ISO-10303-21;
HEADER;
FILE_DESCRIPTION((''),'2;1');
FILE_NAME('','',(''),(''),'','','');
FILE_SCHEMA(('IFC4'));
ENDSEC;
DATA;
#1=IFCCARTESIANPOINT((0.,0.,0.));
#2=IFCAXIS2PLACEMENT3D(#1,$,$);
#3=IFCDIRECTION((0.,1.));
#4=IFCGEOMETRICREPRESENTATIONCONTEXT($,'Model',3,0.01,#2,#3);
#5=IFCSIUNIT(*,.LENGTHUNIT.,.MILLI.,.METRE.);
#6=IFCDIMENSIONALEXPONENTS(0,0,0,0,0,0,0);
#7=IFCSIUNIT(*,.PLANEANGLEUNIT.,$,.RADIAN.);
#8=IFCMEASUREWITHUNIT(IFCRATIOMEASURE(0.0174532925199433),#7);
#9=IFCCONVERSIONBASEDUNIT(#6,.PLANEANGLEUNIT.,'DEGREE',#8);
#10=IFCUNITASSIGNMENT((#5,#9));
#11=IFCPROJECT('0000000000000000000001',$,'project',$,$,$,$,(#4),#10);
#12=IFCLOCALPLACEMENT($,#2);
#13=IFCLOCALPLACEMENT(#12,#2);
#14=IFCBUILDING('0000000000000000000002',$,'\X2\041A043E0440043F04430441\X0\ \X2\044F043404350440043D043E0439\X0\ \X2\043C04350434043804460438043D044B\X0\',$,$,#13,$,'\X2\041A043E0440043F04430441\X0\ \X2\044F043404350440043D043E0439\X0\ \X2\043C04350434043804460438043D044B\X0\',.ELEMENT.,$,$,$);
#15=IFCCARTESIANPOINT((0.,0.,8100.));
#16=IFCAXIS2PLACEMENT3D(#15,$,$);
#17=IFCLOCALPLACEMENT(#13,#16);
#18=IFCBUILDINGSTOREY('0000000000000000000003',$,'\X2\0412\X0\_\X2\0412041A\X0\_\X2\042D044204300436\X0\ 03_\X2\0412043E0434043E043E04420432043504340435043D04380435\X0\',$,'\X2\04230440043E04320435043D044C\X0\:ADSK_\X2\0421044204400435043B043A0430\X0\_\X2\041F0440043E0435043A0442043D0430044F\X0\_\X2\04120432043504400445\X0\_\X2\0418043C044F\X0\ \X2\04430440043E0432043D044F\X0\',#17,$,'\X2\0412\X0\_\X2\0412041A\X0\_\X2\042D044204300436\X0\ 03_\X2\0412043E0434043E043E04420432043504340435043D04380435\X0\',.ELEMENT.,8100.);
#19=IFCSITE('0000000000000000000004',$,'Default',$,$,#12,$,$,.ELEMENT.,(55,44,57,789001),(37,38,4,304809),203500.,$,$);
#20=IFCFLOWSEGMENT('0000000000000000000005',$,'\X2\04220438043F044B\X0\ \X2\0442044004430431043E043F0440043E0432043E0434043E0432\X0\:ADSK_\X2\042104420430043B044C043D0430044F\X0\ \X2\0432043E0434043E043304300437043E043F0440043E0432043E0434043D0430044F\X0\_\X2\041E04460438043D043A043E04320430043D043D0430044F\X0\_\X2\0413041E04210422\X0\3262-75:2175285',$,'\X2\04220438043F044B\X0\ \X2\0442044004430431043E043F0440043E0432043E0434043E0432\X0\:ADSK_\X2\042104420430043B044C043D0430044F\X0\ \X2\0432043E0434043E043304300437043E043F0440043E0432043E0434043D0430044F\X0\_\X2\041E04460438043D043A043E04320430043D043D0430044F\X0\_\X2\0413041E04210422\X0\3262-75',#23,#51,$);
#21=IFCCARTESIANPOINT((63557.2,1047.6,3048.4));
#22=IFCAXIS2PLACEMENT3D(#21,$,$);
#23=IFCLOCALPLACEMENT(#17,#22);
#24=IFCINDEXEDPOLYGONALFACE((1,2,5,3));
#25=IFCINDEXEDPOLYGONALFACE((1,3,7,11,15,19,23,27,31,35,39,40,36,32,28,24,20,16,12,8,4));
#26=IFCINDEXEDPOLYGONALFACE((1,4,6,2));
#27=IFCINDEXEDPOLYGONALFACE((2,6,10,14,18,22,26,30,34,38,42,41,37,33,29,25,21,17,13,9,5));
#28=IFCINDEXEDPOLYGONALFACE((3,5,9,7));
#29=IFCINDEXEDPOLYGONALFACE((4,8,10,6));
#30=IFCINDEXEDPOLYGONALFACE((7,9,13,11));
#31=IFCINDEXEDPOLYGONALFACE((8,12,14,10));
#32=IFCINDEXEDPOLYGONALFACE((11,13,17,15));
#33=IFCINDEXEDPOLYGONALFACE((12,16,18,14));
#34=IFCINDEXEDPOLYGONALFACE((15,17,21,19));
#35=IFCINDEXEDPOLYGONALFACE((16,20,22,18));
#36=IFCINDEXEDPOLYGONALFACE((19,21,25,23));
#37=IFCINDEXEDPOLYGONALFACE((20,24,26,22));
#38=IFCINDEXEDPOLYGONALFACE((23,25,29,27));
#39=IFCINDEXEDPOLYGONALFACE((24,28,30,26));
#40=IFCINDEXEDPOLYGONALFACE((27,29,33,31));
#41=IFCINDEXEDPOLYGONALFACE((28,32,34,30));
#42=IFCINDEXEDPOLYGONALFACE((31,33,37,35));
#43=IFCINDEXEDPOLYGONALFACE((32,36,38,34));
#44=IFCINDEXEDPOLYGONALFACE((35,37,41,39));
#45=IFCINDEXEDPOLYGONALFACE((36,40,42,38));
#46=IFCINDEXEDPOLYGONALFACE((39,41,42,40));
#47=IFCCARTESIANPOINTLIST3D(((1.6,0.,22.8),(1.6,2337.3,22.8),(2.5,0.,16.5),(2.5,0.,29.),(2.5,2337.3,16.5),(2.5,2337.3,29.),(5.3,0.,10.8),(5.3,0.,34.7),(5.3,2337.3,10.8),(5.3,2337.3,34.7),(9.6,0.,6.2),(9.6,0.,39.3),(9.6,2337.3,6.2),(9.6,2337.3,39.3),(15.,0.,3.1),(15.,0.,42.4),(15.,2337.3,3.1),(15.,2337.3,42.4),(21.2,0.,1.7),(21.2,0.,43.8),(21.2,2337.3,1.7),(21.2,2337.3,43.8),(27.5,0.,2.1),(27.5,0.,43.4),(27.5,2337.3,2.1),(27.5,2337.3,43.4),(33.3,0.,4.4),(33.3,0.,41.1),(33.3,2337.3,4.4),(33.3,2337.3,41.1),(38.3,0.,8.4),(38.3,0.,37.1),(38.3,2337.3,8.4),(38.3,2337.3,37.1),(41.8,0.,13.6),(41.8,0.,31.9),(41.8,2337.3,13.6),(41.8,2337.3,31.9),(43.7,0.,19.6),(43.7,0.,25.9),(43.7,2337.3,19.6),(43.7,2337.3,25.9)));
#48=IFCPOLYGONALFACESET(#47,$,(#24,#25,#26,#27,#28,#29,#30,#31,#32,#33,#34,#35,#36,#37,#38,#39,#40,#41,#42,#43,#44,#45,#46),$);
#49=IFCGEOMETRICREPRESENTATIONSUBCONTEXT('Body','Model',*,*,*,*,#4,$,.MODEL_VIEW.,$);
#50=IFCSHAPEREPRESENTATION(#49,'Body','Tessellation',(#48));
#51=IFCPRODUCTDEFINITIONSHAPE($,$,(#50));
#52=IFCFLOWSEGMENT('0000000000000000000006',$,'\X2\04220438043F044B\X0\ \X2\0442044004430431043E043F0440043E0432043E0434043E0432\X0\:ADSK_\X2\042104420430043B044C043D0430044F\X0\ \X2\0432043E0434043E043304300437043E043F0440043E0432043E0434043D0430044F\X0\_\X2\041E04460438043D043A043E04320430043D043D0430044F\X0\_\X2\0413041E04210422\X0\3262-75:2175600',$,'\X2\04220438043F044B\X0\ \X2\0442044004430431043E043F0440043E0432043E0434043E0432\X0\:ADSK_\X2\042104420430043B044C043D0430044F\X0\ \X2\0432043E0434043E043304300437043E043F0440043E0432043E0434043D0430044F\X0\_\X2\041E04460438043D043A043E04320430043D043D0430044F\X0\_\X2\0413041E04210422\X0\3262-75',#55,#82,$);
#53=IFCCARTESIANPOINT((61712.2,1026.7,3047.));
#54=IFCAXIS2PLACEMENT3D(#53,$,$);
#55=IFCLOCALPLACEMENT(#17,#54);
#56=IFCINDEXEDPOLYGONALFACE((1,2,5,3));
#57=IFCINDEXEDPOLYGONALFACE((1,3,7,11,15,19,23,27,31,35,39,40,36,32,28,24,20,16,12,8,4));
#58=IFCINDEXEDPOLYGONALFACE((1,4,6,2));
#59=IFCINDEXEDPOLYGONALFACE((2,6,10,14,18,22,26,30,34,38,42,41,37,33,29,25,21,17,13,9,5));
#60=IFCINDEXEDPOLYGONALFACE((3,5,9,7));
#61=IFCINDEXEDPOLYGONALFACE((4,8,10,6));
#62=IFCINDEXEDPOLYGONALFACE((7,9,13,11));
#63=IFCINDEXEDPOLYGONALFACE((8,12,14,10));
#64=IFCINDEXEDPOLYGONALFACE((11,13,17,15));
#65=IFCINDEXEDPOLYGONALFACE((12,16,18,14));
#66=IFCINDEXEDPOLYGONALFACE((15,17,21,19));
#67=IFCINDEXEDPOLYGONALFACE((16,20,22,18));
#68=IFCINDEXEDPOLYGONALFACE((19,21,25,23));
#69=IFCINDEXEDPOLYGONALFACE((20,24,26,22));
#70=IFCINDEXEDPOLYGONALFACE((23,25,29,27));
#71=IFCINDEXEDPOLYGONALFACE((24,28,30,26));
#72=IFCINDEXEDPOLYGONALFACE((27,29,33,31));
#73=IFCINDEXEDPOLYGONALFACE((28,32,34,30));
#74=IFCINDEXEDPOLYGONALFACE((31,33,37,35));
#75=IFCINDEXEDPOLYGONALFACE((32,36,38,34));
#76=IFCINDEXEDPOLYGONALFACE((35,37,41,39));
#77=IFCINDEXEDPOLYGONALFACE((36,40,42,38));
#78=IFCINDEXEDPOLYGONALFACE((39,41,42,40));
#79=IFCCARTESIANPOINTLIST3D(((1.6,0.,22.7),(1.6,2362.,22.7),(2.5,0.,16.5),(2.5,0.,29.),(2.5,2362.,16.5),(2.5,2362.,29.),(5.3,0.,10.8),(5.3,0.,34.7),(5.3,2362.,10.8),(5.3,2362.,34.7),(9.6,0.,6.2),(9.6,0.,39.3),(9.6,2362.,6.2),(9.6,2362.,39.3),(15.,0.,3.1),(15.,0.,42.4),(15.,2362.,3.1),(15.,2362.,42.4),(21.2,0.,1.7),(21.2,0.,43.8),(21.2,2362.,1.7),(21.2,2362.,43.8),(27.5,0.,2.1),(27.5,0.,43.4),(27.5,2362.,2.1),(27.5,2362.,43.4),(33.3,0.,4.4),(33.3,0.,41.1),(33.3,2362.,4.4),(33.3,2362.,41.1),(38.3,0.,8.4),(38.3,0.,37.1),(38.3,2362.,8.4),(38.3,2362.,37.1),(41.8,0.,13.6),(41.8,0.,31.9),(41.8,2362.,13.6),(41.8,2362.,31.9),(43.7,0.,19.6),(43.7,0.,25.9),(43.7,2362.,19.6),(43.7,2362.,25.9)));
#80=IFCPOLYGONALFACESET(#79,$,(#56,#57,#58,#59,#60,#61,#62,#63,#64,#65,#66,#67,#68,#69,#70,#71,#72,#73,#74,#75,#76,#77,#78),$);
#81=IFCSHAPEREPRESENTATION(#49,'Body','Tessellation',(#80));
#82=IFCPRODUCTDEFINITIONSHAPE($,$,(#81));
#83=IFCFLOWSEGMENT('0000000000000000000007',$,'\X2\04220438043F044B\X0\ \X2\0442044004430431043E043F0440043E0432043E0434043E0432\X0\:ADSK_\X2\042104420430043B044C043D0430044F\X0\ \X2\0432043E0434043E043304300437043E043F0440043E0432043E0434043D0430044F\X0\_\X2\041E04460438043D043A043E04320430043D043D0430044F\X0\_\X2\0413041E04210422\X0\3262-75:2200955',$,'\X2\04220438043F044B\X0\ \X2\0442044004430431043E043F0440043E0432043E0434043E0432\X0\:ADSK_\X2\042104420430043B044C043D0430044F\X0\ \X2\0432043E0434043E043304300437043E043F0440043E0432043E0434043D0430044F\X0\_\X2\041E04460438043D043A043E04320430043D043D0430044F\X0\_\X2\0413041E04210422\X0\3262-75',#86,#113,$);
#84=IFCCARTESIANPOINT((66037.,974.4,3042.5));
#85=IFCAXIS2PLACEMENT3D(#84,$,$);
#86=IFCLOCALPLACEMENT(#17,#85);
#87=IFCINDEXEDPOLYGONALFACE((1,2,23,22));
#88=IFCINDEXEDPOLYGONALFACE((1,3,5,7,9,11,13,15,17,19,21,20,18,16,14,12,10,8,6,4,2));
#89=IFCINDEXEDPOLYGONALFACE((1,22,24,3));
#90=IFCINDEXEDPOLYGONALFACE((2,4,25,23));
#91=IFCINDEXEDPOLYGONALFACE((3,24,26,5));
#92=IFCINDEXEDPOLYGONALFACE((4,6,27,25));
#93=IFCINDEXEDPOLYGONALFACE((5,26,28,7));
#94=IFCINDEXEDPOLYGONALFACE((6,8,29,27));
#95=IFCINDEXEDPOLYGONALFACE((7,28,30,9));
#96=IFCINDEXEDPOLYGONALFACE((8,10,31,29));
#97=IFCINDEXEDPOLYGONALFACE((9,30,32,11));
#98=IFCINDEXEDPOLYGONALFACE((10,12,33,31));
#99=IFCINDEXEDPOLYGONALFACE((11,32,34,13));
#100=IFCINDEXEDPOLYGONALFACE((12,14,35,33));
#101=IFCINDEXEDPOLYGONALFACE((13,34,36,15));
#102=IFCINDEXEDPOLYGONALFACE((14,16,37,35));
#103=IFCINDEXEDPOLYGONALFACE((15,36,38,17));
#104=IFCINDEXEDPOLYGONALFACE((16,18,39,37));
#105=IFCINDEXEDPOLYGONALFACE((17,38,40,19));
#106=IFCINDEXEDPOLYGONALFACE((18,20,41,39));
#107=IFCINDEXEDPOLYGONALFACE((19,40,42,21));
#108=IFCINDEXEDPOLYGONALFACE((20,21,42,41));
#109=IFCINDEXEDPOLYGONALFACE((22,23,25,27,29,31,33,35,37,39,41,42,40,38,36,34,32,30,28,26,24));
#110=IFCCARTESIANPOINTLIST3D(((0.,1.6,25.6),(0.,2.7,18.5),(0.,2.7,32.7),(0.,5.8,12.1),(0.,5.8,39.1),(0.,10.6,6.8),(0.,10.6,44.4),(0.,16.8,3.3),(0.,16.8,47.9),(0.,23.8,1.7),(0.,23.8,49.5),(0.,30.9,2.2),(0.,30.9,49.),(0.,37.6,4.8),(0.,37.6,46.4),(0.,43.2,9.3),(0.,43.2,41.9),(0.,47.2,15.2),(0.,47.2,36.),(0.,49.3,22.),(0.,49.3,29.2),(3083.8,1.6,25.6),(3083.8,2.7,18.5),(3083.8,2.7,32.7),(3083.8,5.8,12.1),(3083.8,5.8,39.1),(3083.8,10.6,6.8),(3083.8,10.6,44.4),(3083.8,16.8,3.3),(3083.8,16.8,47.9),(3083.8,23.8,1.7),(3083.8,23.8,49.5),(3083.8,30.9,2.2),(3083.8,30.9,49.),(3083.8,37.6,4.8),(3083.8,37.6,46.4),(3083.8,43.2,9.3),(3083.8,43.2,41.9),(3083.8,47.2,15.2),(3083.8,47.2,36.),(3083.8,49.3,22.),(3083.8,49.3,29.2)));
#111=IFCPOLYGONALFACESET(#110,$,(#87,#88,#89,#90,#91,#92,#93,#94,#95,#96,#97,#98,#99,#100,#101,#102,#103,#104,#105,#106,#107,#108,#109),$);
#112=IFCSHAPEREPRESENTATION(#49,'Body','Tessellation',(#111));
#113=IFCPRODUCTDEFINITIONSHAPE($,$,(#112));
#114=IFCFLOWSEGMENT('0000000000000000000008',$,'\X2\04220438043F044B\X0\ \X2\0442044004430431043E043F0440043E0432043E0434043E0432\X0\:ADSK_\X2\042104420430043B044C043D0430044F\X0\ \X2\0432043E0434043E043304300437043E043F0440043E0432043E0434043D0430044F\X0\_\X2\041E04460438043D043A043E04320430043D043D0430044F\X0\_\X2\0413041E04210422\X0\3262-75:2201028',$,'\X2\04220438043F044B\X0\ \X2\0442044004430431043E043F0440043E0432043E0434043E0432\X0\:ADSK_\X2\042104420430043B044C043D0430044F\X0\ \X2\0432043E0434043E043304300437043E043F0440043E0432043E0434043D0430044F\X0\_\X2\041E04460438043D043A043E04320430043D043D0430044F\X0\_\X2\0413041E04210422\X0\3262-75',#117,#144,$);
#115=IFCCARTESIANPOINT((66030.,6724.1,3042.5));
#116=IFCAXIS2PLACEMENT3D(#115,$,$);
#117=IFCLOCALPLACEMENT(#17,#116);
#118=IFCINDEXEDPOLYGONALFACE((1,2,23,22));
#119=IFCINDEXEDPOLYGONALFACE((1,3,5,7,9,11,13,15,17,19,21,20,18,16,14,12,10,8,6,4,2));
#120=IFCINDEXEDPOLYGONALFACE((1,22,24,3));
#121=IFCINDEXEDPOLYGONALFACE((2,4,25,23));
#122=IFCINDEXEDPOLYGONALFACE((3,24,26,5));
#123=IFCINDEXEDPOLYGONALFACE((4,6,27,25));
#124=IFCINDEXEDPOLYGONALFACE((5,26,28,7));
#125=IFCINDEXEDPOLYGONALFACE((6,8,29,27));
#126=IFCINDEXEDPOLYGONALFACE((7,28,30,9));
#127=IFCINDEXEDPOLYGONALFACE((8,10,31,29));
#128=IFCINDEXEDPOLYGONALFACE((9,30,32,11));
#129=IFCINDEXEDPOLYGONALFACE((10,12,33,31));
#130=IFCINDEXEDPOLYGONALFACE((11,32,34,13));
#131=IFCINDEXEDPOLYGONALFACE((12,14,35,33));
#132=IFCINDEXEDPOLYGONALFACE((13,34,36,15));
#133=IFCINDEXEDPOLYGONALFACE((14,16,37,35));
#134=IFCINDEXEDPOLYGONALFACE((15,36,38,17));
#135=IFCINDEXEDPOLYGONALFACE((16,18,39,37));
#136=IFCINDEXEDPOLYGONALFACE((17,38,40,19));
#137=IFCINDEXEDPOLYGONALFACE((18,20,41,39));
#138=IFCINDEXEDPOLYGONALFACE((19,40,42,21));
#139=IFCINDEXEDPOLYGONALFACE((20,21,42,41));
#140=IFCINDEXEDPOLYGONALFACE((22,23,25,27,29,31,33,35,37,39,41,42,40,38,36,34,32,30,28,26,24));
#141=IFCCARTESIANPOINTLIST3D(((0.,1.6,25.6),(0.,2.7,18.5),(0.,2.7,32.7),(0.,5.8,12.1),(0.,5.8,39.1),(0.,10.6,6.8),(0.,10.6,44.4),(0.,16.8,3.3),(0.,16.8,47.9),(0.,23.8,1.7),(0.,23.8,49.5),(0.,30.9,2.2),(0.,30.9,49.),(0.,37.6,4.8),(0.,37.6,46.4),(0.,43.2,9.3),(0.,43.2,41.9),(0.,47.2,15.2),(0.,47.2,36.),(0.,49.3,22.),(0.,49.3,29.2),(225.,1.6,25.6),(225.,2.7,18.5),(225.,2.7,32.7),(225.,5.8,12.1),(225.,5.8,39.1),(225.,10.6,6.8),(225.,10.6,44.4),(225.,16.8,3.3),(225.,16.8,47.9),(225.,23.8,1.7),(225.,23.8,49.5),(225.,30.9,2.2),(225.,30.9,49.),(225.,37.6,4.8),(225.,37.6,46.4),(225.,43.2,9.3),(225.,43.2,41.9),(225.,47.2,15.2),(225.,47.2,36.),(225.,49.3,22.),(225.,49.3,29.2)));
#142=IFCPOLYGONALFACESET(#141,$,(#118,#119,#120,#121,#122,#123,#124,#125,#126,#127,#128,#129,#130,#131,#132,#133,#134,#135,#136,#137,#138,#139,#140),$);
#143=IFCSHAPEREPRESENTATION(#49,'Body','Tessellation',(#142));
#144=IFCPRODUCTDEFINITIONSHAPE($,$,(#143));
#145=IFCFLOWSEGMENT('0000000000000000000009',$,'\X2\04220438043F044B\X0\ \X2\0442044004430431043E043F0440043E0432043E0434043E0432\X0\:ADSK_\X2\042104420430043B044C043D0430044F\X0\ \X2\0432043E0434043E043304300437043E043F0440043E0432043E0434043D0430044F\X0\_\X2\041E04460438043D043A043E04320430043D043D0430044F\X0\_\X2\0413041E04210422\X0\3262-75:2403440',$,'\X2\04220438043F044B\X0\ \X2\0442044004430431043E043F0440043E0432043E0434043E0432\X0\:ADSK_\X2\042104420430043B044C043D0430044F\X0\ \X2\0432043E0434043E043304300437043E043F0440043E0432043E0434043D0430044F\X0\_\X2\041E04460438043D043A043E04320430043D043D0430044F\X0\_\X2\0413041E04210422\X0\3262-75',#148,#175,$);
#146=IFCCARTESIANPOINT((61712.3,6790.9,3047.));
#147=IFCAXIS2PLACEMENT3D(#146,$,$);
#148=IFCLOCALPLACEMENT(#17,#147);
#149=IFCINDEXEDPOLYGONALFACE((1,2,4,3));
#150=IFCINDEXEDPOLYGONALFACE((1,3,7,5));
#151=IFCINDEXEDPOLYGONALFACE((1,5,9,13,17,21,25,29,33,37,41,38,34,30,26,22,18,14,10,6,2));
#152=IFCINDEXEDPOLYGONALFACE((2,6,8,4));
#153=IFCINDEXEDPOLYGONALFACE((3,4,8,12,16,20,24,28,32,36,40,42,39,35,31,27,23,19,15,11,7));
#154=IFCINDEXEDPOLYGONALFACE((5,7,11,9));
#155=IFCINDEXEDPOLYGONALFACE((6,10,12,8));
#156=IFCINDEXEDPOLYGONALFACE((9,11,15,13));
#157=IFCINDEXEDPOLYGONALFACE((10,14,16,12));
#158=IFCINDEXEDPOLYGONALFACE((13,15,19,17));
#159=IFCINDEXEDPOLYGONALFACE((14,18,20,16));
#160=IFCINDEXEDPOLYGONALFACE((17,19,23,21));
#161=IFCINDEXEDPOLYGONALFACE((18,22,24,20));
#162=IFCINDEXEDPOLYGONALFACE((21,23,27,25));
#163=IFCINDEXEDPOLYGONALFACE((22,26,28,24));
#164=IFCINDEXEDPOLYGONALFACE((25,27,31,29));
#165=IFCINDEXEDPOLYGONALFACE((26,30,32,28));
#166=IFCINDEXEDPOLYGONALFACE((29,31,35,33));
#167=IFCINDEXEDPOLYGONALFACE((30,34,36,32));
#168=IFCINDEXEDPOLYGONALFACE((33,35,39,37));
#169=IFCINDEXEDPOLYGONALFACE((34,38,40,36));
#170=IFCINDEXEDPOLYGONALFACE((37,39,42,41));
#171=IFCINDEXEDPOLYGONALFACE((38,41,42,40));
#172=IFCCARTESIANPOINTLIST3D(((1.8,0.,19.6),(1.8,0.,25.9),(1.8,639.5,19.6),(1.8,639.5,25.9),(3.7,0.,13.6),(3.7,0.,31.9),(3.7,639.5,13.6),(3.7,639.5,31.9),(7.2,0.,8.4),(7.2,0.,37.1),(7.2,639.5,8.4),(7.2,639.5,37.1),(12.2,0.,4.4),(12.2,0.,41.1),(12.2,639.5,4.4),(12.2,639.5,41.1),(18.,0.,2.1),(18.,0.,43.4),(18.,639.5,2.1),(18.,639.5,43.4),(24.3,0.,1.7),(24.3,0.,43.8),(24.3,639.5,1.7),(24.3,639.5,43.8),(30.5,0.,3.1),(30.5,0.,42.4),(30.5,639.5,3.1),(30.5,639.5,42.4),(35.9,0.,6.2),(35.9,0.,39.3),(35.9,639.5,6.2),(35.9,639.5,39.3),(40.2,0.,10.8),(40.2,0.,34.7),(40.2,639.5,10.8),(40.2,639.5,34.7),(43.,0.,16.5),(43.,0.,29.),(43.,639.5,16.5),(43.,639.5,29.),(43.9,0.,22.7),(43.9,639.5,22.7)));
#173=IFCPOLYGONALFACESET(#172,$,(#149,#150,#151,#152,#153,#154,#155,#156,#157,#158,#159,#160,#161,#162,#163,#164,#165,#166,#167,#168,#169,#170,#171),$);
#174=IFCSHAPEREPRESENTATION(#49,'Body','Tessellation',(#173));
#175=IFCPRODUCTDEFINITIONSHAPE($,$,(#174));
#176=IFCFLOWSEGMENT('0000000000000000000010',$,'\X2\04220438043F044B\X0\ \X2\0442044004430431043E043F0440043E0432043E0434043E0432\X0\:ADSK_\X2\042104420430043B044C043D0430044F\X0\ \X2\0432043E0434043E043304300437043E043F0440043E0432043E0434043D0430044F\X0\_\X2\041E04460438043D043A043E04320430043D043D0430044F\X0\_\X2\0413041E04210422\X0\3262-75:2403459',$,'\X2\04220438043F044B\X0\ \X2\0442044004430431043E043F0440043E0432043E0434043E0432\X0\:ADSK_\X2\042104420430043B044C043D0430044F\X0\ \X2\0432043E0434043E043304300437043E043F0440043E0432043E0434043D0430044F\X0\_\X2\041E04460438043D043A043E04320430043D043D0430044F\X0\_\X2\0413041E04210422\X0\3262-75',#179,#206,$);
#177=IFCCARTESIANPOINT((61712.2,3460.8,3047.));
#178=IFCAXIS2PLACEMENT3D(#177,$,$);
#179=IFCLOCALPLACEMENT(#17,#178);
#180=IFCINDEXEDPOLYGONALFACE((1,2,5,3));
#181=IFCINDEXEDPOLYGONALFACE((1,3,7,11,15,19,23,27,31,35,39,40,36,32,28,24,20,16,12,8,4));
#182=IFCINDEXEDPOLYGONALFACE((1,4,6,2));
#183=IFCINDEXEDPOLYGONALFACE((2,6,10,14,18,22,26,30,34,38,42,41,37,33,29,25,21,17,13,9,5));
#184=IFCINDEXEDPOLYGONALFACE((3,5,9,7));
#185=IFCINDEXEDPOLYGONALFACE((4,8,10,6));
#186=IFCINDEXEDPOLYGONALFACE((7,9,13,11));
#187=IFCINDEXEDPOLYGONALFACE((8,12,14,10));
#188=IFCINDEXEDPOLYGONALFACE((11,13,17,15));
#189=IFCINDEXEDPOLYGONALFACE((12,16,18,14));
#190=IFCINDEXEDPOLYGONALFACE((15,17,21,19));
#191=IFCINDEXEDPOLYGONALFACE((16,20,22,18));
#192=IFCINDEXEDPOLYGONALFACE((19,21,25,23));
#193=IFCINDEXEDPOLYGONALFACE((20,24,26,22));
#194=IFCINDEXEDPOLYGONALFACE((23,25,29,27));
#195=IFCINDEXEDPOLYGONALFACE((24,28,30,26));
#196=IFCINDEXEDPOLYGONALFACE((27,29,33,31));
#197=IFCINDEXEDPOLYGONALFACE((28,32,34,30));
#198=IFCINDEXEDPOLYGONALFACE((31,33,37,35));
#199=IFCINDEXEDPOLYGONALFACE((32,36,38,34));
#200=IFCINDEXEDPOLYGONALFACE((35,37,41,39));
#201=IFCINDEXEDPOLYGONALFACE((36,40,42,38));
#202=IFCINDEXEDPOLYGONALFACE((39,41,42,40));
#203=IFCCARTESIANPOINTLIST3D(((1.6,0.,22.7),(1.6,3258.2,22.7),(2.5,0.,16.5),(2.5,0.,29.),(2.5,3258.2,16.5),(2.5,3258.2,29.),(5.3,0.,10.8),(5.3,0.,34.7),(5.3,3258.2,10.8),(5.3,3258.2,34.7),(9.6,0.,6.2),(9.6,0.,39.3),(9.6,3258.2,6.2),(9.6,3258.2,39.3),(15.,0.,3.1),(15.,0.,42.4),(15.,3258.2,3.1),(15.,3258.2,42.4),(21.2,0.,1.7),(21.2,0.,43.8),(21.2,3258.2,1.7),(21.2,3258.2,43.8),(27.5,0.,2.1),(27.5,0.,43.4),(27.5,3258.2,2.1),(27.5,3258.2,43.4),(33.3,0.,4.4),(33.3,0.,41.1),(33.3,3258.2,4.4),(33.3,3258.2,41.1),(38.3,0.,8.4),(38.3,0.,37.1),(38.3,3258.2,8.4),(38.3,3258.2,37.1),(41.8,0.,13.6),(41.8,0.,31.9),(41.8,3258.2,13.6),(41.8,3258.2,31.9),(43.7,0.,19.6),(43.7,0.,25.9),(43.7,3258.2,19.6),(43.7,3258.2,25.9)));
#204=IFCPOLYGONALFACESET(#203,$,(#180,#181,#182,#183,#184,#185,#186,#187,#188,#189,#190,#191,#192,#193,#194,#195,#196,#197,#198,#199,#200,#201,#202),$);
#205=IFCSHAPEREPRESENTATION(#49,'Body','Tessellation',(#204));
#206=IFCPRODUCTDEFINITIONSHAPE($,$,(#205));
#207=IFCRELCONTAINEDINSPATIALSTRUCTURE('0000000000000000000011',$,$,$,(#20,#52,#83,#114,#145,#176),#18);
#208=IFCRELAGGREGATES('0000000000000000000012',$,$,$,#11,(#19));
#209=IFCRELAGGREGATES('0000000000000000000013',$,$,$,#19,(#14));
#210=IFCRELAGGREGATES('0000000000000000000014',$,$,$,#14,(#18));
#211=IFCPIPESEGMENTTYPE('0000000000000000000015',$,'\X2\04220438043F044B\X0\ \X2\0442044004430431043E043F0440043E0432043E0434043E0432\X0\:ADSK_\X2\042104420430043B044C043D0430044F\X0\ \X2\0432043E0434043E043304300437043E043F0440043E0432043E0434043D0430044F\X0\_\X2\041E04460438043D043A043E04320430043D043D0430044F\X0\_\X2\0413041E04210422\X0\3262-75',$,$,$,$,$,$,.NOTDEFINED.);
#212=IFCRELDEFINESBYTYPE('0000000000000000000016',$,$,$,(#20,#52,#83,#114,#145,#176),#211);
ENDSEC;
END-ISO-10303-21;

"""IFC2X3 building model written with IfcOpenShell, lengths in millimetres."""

from ifc_helpers import new_model, entity, si_unit, converted_unit, direction, frame, origin, origin_2d_with_axis, place, context, subcontext, project, spatial, circle, extrude, type_object, element, save


model = new_model("IFC2X3")

# Units and contexts
model_context = context("Model", 3, precision=0.01, world=origin(), true_north=direction((0.0, 1.0)))
body_context = subcontext(model_context, "Body", "Model", "MODEL_VIEW")
ifc_project = project(units=[si_unit("LENGTHUNIT", "METRE", prefix="MILLI"), converted_unit("PLANEANGLEUNIT", "DEGREE", entity("IfcRatioMeasure", 0.0174532925199433), si_unit("PLANEANGLEUNIT", "RADIAN"), dimensions=[0, 0, 0, 0, 0, 0, 0])], contexts=[model_context])

# Site, building, storey
site_placement = place(None, origin())
site = spatial("IfcSite", under=ifc_project, at=site_placement, Name="Default", CompositionType="ELEMENT", RefLatitude=(55, 44, 57, 789001), RefLongitude=(37, 38, 4, 304809), RefElevation=203500.0)
building_placement = place(site_placement, origin())
building = spatial("IfcBuilding", under=site, at=building_placement, Name="Корпус ядерной медицины", LongName="Корпус ядерной медицины", CompositionType="ELEMENT")
storey_placement = place(building_placement, frame((0.0, 0.0, 8100.0)))
storey = spatial("IfcBuildingStorey", under=building, at=storey_placement, Name="В_ВК_Этаж 03_Водоотведение", ObjectType="Уровень:ADSK_Стрелка_Проектная_Вверх_Имя уровня", LongName="В_ВК_Этаж 03_Водоотведение", CompositionType="ELEMENT", Elevation=8100.0)

# Flow segments
pipe_segment_type_1 = type_object("IfcPipeSegmentType", Name="Типы трубопроводов:ADSK_Стальная водогазопроводная_Оцинкованная_ГОСТ3262-75", PredefinedType="NOTDEFINED")
flow_segment_1_placement = place(storey_placement, frame((63557.2, 1047.6, 3048.4)))
element("IfcFlowSegment", 1, at=flow_segment_1_placement, inside=storey, type_object=pipe_segment_type_1, Name="Типы трубопроводов:ADSK_Стальная водогазопроводная_Оцинкованная_ГОСТ3262-75:2175285", ObjectType="Типы трубопроводов:ADSK_Стальная водогазопроводная_Оцинкованная_ГОСТ3262-75", context=body_context, shape_type="SweptSolid", body=[
    extrude(circle(Radius=21.1, at=origin_2d_with_axis()), frame((22.8, 0.0, 22.8), z_axis=(0.0, 1.0, 0.0), x_axis=(-1.0, 0.0, 0.0)), (0.0, 0.0, 1.0), 2337.3),
])
flow_segment_2_placement = place(storey_placement, frame((61712.2, 1026.7, 3047.0)))
element("IfcFlowSegment", 2, at=flow_segment_2_placement, inside=storey, type_object=pipe_segment_type_1, Name="Типы трубопроводов:ADSK_Стальная водогазопроводная_Оцинкованная_ГОСТ3262-75:2175600", ObjectType="Типы трубопроводов:ADSK_Стальная водогазопроводная_Оцинкованная_ГОСТ3262-75", context=body_context, shape_type="SweptSolid", body=[
    extrude(circle(Radius=21.1, at=origin_2d_with_axis()), frame((22.8, 0.0, 22.8), z_axis=(0.0, 1.0, 0.0), x_axis=(-1.0, 0.0, 0.0)), (0.0, 0.0, 1.0), 2362.0),
])
flow_segment_3_placement = place(storey_placement, frame((66037.0, 974.4, 3042.5)))
element("IfcFlowSegment", 3, at=flow_segment_3_placement, inside=storey, type_object=pipe_segment_type_1, Name="Типы трубопроводов:ADSK_Стальная водогазопроводная_Оцинкованная_ГОСТ3262-75:2200955", ObjectType="Типы трубопроводов:ADSK_Стальная водогазопроводная_Оцинкованная_ГОСТ3262-75", context=body_context, shape_type="SweptSolid", body=[
    extrude(circle(Radius=24.0, at=origin_2d_with_axis()), frame((0.0, 25.6, 25.6), z_axis=(1.0, 0.0, 0.0), x_axis=(0.0, -1.0, 0.0)), (0.0, 0.0, 1.0), 3083.8),
])
flow_segment_4_placement = place(storey_placement, frame((66030.0, 6724.1, 3042.5)))
element("IfcFlowSegment", 4, at=flow_segment_4_placement, inside=storey, type_object=pipe_segment_type_1, Name="Типы трубопроводов:ADSK_Стальная водогазопроводная_Оцинкованная_ГОСТ3262-75:2201028", ObjectType="Типы трубопроводов:ADSK_Стальная водогазопроводная_Оцинкованная_ГОСТ3262-75", context=body_context, shape_type="SweptSolid", body=[
    extrude(circle(Radius=24.0, at=origin_2d_with_axis()), frame((0.0, 25.6, 25.6), z_axis=(1.0, 0.0, 0.0), x_axis=(0.0, -1.0, 0.0)), (0.0, 0.0, 1.0), 225.0),
])
flow_segment_5_placement = place(storey_placement, frame((61712.3, 6790.9, 3047.0)))
element("IfcFlowSegment", 5, at=flow_segment_5_placement, inside=storey, type_object=pipe_segment_type_1, Name="Типы трубопроводов:ADSK_Стальная водогазопроводная_Оцинкованная_ГОСТ3262-75:2403440", ObjectType="Типы трубопроводов:ADSK_Стальная водогазопроводная_Оцинкованная_ГОСТ3262-75", context=body_context, shape_type="SweptSolid", body=[
    extrude(circle(Radius=21.1, at=origin_2d_with_axis()), frame((22.8, 0.0, 22.8), z_axis=(0.0, 1.0, 0.0), x_axis=(1.0, 0.0, 0.0)), (0.0, 0.0, 1.0), 639.5),
])
flow_segment_6_placement = place(storey_placement, frame((61712.2, 3460.8, 3047.0)))
element("IfcFlowSegment", 6, at=flow_segment_6_placement, inside=storey, type_object=pipe_segment_type_1, Name="Типы трубопроводов:ADSK_Стальная водогазопроводная_Оцинкованная_ГОСТ3262-75:2403459", ObjectType="Типы трубопроводов:ADSK_Стальная водогазопроводная_Оцинкованная_ГОСТ3262-75", context=body_context, shape_type="SweptSolid", body=[
    extrude(circle(Radius=21.1, at=origin_2d_with_axis()), frame((22.8, 0.0, 22.8), z_axis=(0.0, 1.0, 0.0), x_axis=(-1.0, 0.0, 0.0)), (0.0, 0.0, 1.0), 3258.2),
])

save(model, "model.ifc")
